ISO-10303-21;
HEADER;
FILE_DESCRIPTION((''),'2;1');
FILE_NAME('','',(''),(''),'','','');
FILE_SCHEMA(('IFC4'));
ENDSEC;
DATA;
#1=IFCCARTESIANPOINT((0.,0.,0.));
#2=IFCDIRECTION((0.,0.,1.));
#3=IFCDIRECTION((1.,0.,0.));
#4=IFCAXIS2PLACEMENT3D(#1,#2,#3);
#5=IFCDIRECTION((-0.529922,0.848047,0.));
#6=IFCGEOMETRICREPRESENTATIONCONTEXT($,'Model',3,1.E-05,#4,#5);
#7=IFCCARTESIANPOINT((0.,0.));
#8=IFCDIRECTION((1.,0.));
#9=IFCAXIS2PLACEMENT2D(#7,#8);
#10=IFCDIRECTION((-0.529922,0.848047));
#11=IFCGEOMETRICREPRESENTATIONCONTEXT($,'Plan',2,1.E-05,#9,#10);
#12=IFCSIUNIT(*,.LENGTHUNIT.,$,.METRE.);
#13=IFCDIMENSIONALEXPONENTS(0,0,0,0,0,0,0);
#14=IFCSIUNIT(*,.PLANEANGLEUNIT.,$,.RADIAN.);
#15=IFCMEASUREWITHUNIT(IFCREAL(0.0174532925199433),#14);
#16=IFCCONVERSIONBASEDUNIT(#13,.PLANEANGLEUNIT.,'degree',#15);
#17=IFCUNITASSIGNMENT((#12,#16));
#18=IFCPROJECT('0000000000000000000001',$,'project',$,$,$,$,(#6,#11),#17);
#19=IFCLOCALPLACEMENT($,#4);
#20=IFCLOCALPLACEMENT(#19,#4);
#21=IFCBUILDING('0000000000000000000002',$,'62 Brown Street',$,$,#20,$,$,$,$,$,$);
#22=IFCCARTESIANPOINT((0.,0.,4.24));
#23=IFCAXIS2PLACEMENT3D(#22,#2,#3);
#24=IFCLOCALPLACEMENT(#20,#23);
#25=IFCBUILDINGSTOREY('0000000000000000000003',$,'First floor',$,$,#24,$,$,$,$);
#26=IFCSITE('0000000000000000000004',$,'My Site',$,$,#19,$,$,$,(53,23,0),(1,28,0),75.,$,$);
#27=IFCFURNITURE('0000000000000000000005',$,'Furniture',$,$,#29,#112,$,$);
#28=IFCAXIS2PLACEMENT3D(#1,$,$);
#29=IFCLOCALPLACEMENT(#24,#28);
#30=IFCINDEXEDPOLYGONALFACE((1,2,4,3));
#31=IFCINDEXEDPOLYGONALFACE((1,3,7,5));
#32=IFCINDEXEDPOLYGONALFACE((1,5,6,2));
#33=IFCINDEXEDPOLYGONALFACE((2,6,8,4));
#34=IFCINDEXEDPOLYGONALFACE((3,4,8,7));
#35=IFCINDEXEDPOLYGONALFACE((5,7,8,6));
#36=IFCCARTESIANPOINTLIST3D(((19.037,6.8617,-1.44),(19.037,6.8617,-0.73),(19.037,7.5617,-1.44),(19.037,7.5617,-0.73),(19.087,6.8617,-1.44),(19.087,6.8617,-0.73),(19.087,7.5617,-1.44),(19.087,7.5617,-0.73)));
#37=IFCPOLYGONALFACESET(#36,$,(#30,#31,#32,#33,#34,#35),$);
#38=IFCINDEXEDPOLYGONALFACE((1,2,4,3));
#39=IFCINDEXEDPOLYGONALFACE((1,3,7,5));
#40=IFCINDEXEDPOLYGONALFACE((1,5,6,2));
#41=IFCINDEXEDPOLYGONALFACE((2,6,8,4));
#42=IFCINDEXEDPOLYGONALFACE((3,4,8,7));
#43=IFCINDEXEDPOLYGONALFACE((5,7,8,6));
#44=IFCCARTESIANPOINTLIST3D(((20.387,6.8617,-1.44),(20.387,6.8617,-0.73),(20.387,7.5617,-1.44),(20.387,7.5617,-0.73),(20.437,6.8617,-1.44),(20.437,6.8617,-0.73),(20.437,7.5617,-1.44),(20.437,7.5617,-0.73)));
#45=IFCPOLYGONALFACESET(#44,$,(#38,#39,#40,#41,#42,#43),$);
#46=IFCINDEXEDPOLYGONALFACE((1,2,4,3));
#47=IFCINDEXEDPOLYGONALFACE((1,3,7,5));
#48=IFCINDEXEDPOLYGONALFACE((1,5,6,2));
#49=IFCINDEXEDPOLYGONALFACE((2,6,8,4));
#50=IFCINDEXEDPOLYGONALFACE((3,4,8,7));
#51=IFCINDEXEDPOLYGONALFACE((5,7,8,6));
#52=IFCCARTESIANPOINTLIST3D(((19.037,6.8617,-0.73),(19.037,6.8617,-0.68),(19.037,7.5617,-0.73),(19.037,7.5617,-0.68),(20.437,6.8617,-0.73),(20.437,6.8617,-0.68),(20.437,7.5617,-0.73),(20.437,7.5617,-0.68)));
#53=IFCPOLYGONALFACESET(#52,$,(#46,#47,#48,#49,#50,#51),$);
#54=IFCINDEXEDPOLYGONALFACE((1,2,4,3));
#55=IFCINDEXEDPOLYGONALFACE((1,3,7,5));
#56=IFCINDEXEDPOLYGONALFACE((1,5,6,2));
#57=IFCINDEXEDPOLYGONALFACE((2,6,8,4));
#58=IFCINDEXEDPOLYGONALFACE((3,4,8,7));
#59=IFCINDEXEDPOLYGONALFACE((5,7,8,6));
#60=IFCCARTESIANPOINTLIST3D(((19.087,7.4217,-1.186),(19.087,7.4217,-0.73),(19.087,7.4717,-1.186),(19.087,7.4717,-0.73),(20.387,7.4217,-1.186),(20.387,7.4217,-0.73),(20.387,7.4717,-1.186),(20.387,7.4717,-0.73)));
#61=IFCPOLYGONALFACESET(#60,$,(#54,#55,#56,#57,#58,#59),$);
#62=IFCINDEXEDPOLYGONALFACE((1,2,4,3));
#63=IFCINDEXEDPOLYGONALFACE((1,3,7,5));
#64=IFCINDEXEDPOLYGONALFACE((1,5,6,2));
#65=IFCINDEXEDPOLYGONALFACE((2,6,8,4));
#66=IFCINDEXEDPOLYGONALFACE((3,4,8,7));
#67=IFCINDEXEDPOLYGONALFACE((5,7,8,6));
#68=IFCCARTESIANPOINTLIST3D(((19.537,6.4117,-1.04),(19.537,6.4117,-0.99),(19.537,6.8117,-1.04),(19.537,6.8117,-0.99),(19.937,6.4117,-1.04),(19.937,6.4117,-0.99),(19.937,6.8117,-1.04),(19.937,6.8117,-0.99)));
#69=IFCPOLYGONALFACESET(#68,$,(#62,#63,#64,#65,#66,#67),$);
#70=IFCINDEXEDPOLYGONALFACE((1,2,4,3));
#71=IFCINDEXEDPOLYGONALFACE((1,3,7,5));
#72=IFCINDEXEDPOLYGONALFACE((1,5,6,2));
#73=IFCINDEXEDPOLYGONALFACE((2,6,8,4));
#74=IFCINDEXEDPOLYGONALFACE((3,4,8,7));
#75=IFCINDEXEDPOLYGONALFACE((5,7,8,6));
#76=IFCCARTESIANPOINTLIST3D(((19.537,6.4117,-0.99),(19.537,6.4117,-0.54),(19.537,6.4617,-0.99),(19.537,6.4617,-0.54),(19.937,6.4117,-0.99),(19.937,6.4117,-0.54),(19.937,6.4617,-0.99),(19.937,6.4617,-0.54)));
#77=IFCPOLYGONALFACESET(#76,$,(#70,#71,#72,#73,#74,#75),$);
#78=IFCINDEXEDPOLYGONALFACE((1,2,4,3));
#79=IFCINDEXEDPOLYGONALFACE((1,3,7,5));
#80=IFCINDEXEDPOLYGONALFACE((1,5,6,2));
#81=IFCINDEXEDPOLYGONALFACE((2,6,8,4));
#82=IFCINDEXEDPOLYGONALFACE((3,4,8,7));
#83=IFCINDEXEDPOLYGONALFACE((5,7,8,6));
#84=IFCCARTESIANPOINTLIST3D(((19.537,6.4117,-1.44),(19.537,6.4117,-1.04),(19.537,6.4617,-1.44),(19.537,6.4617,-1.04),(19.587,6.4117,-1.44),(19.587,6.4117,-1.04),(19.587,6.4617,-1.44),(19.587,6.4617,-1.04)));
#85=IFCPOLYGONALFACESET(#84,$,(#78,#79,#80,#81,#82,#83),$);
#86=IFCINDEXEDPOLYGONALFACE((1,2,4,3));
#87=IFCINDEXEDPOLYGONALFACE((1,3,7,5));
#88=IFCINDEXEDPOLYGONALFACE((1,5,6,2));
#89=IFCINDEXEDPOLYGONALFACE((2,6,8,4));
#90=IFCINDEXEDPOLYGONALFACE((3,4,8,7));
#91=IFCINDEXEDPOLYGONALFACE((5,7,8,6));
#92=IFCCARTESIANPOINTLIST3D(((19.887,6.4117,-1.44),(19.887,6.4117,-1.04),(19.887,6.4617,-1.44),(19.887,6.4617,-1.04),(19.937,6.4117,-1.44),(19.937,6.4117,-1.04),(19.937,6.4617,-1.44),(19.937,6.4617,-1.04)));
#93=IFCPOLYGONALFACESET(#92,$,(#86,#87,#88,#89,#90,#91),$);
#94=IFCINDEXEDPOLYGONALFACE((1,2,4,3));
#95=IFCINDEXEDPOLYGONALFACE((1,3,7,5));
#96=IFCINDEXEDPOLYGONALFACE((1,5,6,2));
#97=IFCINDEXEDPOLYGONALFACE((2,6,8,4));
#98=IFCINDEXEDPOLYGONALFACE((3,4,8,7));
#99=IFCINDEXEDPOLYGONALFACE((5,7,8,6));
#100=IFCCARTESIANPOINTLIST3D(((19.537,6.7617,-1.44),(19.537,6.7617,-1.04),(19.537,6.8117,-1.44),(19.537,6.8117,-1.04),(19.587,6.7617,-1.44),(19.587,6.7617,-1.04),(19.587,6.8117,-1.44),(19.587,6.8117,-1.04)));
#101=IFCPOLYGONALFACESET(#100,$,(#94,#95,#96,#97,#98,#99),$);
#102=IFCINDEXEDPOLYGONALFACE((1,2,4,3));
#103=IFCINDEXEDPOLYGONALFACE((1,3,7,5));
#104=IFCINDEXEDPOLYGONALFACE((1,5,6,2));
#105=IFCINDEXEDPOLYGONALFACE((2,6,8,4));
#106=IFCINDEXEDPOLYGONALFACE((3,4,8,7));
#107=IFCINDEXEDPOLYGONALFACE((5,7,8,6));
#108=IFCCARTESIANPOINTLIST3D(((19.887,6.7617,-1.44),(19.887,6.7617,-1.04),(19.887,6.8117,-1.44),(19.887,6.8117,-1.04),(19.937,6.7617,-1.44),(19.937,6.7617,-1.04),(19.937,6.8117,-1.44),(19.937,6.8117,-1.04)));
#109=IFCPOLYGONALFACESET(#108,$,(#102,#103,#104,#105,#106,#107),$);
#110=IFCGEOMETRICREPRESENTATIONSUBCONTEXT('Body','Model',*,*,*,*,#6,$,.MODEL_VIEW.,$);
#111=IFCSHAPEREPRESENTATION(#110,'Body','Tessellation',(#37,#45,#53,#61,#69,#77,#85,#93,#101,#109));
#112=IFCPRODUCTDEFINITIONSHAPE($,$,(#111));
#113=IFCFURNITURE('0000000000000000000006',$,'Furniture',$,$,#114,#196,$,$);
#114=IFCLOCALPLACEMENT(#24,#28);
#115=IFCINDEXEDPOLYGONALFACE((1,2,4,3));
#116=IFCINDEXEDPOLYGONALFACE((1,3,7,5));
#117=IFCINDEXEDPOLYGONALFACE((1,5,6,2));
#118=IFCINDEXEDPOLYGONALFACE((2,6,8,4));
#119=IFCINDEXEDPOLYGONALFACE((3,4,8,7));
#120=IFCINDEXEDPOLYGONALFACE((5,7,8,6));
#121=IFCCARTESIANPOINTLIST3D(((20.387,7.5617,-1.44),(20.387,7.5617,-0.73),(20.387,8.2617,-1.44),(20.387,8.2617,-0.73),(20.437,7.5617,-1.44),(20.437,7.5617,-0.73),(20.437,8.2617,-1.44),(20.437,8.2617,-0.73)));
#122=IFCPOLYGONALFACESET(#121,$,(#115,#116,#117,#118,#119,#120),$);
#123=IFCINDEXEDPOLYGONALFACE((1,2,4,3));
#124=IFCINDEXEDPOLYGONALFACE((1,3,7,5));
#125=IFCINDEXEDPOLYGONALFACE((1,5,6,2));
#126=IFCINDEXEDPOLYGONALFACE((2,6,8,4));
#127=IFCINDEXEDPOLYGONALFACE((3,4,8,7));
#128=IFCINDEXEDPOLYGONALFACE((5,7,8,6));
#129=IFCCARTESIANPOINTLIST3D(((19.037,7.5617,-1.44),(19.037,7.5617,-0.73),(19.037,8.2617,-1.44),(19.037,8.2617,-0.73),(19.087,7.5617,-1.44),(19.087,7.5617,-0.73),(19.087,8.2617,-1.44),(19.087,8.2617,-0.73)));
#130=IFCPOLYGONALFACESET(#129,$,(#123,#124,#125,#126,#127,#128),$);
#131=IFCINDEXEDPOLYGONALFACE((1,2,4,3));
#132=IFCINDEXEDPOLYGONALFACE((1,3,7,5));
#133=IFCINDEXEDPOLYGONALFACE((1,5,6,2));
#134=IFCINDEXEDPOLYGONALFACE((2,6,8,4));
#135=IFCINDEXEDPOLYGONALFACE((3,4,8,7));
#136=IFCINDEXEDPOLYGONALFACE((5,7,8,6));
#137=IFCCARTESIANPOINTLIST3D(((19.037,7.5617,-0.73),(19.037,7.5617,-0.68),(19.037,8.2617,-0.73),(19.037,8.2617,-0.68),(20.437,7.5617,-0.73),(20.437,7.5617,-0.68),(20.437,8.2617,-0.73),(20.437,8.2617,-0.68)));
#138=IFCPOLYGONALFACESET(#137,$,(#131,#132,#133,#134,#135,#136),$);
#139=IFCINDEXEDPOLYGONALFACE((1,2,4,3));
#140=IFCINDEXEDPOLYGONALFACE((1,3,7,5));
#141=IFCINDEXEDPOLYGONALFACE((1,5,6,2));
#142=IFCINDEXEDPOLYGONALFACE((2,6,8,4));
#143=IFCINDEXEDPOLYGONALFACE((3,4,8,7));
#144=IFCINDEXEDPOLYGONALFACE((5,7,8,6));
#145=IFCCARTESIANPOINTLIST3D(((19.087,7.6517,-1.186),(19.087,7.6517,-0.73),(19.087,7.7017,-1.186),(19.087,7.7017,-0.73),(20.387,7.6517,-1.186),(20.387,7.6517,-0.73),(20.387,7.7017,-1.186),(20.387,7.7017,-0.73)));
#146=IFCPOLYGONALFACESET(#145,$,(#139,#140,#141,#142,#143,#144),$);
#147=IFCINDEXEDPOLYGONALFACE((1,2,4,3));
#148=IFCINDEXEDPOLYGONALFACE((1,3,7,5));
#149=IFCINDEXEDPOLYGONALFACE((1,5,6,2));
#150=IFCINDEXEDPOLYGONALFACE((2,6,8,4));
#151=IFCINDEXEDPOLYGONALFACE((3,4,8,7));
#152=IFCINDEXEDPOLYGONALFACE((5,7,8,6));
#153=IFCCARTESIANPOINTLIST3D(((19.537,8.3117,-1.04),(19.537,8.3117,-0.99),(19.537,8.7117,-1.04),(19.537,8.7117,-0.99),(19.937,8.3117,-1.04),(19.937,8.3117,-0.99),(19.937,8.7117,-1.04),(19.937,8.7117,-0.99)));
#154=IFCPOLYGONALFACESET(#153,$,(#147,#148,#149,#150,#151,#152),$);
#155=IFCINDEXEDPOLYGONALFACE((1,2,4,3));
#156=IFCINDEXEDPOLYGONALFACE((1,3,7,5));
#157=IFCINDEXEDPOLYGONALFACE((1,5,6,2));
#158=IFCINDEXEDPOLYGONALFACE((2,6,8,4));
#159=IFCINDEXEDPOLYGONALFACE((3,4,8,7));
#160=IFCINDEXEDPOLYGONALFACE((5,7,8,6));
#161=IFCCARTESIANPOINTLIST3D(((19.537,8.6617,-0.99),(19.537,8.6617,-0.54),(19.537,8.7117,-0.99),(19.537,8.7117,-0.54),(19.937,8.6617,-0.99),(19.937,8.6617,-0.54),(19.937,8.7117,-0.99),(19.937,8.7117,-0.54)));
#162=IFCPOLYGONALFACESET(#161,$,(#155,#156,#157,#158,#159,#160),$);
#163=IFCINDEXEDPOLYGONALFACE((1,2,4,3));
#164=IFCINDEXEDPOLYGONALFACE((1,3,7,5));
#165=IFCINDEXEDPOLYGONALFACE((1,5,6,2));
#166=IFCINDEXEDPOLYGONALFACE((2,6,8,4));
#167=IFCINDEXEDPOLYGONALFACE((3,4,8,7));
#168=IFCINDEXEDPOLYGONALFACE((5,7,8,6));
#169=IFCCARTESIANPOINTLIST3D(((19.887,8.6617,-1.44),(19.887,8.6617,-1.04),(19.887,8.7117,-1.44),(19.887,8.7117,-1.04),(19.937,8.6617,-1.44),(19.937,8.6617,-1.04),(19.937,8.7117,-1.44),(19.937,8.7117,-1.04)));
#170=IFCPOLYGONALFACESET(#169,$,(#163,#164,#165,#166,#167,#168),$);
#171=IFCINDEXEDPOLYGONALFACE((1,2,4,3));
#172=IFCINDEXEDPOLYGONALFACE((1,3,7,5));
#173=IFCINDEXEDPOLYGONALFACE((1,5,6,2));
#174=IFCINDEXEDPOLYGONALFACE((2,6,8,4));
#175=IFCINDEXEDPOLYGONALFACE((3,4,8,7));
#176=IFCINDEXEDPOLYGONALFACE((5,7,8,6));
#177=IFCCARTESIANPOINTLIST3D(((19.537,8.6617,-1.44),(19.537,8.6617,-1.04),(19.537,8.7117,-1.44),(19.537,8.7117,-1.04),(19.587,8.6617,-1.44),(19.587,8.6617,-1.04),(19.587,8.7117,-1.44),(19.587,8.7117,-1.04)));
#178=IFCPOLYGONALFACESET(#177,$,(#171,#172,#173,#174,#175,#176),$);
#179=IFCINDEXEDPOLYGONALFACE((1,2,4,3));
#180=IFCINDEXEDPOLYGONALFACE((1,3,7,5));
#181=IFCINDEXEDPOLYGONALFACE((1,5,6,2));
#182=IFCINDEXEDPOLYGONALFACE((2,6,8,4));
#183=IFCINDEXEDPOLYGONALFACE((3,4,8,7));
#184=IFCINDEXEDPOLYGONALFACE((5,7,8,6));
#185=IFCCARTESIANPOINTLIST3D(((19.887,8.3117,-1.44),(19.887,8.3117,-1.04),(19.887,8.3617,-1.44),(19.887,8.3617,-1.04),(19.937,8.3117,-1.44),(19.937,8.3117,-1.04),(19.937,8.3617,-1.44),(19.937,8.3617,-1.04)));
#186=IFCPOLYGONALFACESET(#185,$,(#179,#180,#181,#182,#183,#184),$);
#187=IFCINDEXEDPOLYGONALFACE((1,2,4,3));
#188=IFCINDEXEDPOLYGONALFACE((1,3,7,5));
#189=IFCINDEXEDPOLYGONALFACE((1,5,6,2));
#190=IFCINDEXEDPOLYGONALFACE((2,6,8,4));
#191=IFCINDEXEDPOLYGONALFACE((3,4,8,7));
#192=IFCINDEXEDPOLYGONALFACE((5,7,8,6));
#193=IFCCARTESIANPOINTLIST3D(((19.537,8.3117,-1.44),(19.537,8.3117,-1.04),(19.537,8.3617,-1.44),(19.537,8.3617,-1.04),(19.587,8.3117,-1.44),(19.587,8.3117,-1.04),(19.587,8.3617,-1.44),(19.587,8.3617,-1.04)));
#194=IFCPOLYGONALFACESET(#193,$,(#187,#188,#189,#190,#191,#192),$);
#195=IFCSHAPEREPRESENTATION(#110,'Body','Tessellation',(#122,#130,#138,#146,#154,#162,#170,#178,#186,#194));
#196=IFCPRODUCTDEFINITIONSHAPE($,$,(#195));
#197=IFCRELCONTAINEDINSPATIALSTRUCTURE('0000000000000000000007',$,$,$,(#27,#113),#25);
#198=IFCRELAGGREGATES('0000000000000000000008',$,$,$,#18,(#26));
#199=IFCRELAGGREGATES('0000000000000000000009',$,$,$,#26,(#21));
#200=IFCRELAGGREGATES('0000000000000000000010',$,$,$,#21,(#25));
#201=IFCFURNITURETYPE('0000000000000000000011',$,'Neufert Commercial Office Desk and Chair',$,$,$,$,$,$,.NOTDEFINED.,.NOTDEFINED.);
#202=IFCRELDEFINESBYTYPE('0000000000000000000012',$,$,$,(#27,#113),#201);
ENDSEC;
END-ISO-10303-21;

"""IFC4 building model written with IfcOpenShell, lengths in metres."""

from ifc_helpers import new_model, entity, si_unit, converted_unit, direction, frame, origin_with_axes, origin_2d_with_axis, place, context, subcontext, project, spatial, line, indexed_curve, outline, extrude, shape, source, transform, mapped, type_object, type_shapes, element, save


model = new_model("IFC4")

# Units and contexts
model_context = context("Model", 3, precision=1e-05, world=origin_with_axes(), true_north=direction((-0.529922, 0.848047, 0.0)))
plan_context = context("Plan", 2, precision=1e-05, world=origin_2d_with_axis(), true_north=direction((-0.529922, 0.848047)))
body_context_1 = subcontext(model_context, "Body", "Model", "MODEL_VIEW")
body_context_2 = subcontext(plan_context, "Body", "Plan", "PLAN_VIEW")
ifc_project = project(units=[si_unit("LENGTHUNIT", "METRE"), converted_unit("PLANEANGLEUNIT", "degree", entity("IfcReal", 0.0174532925199433), si_unit("PLANEANGLEUNIT", "RADIAN"), dimensions=[0, 0, 0, 0, 0, 0, 0])], contexts=[model_context, plan_context])

# Site, building, storey
site_placement = place(None, origin_with_axes())
site = spatial("IfcSite", under=ifc_project, at=site_placement, Name="My Site", RefLatitude=(53, 23, 0), RefLongitude=(1, 28, 0), RefElevation=75.0)
building_placement = place(site_placement, origin_with_axes())
building = spatial("IfcBuilding", under=site, at=building_placement, Name="62 Brown Street")
storey_placement = place(building_placement, frame((0.0, 0.0, 4.24), z_axis=(0.0, 0.0, 1.0), x_axis=(1.0, 0.0, 0.0)))
storey = spatial("IfcBuildingStorey", under=building, at=storey_placement, Name="First floor")

# Furniture
furniture_type = type_object("IfcFurnitureType", Name="Neufert Commercial Office Desk and Chair", AssemblyPlace="NOTDEFINED", PredefinedType="NOTDEFINED")
shared_shape_1 = source(origin_with_axes(), body_context_1, "Body", "SweptSolid", [
    extrude(outline(indexed_curve([(0.0, 0.0), (0.05, 0.0), (0.05, 0.7), (0.0, 0.7)], segments=[line(1, 2, 3, 4, 1)])), frame((0.0, 0.45, 0.0), z_axis=(0.0, 0.0, 1.0), x_axis=(1.0, 0.0, 0.0)), (0.0, 0.0, 1.0), 0.71),
    extrude(outline(indexed_curve([(0.0, 0.0), (0.05, 0.0), (0.05, 0.7), (0.0, 0.7)], segments=[line(1, 2, 3, 4, 1)])), frame((1.35, 0.45, 0.0), z_axis=(0.0, 0.0, 1.0), x_axis=(1.0, 0.0, 0.0)), (0.0, 0.0, 1.0), 0.71),
    extrude(outline(indexed_curve([(0.0, 0.0), (1.4, 0.0), (1.4, 0.7), (0.0, 0.7)], segments=[line(1, 2, 3, 4, 1)])), frame((0.0, 0.45, 0.71), z_axis=(0.0, 0.0, 1.0), x_axis=(1.0, 0.0, 0.0)), (0.0, 0.0, 1.0), 0.05),
    extrude(outline(indexed_curve([(0.05, 0.56), (1.35, 0.56), (1.35, 0.61), (0.05, 0.61)], segments=[line(1, 2, 3, 4, 1)])), frame((0.0, 0.45, 0.254), z_axis=(0.0, 0.0, 1.0), x_axis=(1.0, 0.0, 0.0)), (0.0, 0.0, 1.0), 0.456),
    extrude(outline(indexed_curve([(-0.2, 0.0), (0.2, 0.0), (0.2, 0.4), (-0.2, 0.4)], segments=[line(1, 2, 3, 4, 1)])), frame((0.7, 0.0, 0.45), z_axis=(0.0, 0.0, 1.0), x_axis=(1.0, 0.0, 0.0)), (0.0, 0.0, -1.0), 0.05),
    extrude(outline(indexed_curve([(-0.2, 0.0), (0.2, 0.0), (0.2, 0.05), (-0.2, 0.05)], segments=[line(1, 2, 3, 4, 1)])), frame((0.7, 0.0, 0.9), z_axis=(0.0, 0.0, 1.0), x_axis=(1.0, 0.0, 0.0)), (0.0, 0.0, -1.0), 0.45),
    extrude(outline(indexed_curve([(-0.2, 0.0), (-0.15, 0.0), (-0.15, 0.05), (-0.2, 0.05)], segments=[line(1, 2, 3, 4, 1)])), frame((0.7, 0.0, 0.0), z_axis=(0.0, 0.0, 1.0), x_axis=(1.0, 0.0, 0.0)), (0.0, 0.0, 1.0), 0.4),
    extrude(outline(indexed_curve([(0.2, 0.0), (0.15, 0.0), (0.15, 0.05), (0.2, 0.05)], segments=[line(1, 2, 3, 4, 1)])), frame((0.7, 0.0, 0.0), z_axis=(0.0, 0.0, 1.0), x_axis=(1.0, 0.0, 0.0)), (0.0, 0.0, 1.0), 0.4),
    extrude(outline(indexed_curve([(-0.2, 0.4), (-0.15, 0.4), (-0.15, 0.35), (-0.2, 0.35)], segments=[line(1, 2, 3, 4, 1)])), frame((0.7, 0.0, 0.0), z_axis=(0.0, 0.0, 1.0), x_axis=(1.0, 0.0, 0.0)), (0.0, 0.0, 1.0), 0.4),
    extrude(outline(indexed_curve([(0.2, 0.4), (0.15, 0.4), (0.15, 0.35), (0.2, 0.35)], segments=[line(1, 2, 3, 4, 1)])), frame((0.7, 0.0, 0.0), z_axis=(0.0, 0.0, 1.0), x_axis=(1.0, 0.0, 0.0)), (0.0, 0.0, 1.0), 0.4),
])
shared_shape_2 = source(origin_with_axes(), body_context_2, "Body", "Curve2D", [
    entity("IfcIndexedPolyCurve", entity("IfcCartesianPointList2D", [[0.0, 0.45], [1.4, 0.45], [1.4, 1.15], [0.0, 1.15]]), [entity("IfcLineIndex", [1, 2, 3, 4, 1])]),
    entity("IfcIndexedPolyCurve", entity("IfcCartesianPointList2D", [[0.5, 0.4], [0.9, 0.4]])),
    entity("IfcIndexedPolyCurve", entity("IfcCartesianPointList2D", [[0.5, 0.4], [0.5, 0.2], [0.5586, 0.0586], [0.7, 0.0], [0.8414, 0.0586], [0.9, 0.2], [0.9, 0.4]]), [entity("IfcLineIndex", [1, 2]), entity("IfcArcIndex", [2, 3, 4]), entity("IfcArcIndex", [4, 5, 6]), entity("IfcLineIndex", [6, 7])]),
    entity("IfcIndexedPolyCurve", entity("IfcCartesianPointList2D", [[0.54, 0.4], [0.54, 0.2], [0.5869, 0.0869], [0.7, 0.04], [0.8131, 0.0869], [0.86, 0.2], [0.86, 0.4]]), [entity("IfcLineIndex", [1, 2]), entity("IfcArcIndex", [2, 3, 4]), entity("IfcArcIndex", [4, 5, 6]), entity("IfcLineIndex", [6, 7])]),
])
type_shapes(furniture_type, [shared_shape_1, shared_shape_2])
for number, where, z_axis, x_axis, name in (
    (1, (19.037, 6.4117, -1.44), (0.0, 0.0, 1.0), (1.0, 0.0, 0.0), "Furniture"),
    (2, (20.437, 8.7117, -1.44), (0.0, 0.0, 1.0), (-1.0, 0.0, 0.0), "Furniture"),
):
    element("IfcFurniture", number, at=place(storey_placement, frame(where, z_axis=z_axis, x_axis=x_axis)), inside=storey, type_object=furniture_type, Name=name, shapes=[
        shape(body_context_1, "Body", "MappedRepresentation", [mapped(shared_shape_1, transform((0.0, 0.0, 0.0), x_axis=(1.0, 0.0, 0.0), y_axis=(0.0, 1.0, 0.0), z_axis=(0.0, 0.0, 1.0), scale=1.0))]),
        shape(body_context_2, "Body", "MappedRepresentation", [mapped(shared_shape_2, transform((0.0, 0.0, 0.0), x_axis=(1.0, 0.0, 0.0), y_axis=(0.0, 1.0, 0.0), z_axis=(0.0, 0.0, 1.0), scale=1.0))]),
    ])

save(model, "model.ifc")
